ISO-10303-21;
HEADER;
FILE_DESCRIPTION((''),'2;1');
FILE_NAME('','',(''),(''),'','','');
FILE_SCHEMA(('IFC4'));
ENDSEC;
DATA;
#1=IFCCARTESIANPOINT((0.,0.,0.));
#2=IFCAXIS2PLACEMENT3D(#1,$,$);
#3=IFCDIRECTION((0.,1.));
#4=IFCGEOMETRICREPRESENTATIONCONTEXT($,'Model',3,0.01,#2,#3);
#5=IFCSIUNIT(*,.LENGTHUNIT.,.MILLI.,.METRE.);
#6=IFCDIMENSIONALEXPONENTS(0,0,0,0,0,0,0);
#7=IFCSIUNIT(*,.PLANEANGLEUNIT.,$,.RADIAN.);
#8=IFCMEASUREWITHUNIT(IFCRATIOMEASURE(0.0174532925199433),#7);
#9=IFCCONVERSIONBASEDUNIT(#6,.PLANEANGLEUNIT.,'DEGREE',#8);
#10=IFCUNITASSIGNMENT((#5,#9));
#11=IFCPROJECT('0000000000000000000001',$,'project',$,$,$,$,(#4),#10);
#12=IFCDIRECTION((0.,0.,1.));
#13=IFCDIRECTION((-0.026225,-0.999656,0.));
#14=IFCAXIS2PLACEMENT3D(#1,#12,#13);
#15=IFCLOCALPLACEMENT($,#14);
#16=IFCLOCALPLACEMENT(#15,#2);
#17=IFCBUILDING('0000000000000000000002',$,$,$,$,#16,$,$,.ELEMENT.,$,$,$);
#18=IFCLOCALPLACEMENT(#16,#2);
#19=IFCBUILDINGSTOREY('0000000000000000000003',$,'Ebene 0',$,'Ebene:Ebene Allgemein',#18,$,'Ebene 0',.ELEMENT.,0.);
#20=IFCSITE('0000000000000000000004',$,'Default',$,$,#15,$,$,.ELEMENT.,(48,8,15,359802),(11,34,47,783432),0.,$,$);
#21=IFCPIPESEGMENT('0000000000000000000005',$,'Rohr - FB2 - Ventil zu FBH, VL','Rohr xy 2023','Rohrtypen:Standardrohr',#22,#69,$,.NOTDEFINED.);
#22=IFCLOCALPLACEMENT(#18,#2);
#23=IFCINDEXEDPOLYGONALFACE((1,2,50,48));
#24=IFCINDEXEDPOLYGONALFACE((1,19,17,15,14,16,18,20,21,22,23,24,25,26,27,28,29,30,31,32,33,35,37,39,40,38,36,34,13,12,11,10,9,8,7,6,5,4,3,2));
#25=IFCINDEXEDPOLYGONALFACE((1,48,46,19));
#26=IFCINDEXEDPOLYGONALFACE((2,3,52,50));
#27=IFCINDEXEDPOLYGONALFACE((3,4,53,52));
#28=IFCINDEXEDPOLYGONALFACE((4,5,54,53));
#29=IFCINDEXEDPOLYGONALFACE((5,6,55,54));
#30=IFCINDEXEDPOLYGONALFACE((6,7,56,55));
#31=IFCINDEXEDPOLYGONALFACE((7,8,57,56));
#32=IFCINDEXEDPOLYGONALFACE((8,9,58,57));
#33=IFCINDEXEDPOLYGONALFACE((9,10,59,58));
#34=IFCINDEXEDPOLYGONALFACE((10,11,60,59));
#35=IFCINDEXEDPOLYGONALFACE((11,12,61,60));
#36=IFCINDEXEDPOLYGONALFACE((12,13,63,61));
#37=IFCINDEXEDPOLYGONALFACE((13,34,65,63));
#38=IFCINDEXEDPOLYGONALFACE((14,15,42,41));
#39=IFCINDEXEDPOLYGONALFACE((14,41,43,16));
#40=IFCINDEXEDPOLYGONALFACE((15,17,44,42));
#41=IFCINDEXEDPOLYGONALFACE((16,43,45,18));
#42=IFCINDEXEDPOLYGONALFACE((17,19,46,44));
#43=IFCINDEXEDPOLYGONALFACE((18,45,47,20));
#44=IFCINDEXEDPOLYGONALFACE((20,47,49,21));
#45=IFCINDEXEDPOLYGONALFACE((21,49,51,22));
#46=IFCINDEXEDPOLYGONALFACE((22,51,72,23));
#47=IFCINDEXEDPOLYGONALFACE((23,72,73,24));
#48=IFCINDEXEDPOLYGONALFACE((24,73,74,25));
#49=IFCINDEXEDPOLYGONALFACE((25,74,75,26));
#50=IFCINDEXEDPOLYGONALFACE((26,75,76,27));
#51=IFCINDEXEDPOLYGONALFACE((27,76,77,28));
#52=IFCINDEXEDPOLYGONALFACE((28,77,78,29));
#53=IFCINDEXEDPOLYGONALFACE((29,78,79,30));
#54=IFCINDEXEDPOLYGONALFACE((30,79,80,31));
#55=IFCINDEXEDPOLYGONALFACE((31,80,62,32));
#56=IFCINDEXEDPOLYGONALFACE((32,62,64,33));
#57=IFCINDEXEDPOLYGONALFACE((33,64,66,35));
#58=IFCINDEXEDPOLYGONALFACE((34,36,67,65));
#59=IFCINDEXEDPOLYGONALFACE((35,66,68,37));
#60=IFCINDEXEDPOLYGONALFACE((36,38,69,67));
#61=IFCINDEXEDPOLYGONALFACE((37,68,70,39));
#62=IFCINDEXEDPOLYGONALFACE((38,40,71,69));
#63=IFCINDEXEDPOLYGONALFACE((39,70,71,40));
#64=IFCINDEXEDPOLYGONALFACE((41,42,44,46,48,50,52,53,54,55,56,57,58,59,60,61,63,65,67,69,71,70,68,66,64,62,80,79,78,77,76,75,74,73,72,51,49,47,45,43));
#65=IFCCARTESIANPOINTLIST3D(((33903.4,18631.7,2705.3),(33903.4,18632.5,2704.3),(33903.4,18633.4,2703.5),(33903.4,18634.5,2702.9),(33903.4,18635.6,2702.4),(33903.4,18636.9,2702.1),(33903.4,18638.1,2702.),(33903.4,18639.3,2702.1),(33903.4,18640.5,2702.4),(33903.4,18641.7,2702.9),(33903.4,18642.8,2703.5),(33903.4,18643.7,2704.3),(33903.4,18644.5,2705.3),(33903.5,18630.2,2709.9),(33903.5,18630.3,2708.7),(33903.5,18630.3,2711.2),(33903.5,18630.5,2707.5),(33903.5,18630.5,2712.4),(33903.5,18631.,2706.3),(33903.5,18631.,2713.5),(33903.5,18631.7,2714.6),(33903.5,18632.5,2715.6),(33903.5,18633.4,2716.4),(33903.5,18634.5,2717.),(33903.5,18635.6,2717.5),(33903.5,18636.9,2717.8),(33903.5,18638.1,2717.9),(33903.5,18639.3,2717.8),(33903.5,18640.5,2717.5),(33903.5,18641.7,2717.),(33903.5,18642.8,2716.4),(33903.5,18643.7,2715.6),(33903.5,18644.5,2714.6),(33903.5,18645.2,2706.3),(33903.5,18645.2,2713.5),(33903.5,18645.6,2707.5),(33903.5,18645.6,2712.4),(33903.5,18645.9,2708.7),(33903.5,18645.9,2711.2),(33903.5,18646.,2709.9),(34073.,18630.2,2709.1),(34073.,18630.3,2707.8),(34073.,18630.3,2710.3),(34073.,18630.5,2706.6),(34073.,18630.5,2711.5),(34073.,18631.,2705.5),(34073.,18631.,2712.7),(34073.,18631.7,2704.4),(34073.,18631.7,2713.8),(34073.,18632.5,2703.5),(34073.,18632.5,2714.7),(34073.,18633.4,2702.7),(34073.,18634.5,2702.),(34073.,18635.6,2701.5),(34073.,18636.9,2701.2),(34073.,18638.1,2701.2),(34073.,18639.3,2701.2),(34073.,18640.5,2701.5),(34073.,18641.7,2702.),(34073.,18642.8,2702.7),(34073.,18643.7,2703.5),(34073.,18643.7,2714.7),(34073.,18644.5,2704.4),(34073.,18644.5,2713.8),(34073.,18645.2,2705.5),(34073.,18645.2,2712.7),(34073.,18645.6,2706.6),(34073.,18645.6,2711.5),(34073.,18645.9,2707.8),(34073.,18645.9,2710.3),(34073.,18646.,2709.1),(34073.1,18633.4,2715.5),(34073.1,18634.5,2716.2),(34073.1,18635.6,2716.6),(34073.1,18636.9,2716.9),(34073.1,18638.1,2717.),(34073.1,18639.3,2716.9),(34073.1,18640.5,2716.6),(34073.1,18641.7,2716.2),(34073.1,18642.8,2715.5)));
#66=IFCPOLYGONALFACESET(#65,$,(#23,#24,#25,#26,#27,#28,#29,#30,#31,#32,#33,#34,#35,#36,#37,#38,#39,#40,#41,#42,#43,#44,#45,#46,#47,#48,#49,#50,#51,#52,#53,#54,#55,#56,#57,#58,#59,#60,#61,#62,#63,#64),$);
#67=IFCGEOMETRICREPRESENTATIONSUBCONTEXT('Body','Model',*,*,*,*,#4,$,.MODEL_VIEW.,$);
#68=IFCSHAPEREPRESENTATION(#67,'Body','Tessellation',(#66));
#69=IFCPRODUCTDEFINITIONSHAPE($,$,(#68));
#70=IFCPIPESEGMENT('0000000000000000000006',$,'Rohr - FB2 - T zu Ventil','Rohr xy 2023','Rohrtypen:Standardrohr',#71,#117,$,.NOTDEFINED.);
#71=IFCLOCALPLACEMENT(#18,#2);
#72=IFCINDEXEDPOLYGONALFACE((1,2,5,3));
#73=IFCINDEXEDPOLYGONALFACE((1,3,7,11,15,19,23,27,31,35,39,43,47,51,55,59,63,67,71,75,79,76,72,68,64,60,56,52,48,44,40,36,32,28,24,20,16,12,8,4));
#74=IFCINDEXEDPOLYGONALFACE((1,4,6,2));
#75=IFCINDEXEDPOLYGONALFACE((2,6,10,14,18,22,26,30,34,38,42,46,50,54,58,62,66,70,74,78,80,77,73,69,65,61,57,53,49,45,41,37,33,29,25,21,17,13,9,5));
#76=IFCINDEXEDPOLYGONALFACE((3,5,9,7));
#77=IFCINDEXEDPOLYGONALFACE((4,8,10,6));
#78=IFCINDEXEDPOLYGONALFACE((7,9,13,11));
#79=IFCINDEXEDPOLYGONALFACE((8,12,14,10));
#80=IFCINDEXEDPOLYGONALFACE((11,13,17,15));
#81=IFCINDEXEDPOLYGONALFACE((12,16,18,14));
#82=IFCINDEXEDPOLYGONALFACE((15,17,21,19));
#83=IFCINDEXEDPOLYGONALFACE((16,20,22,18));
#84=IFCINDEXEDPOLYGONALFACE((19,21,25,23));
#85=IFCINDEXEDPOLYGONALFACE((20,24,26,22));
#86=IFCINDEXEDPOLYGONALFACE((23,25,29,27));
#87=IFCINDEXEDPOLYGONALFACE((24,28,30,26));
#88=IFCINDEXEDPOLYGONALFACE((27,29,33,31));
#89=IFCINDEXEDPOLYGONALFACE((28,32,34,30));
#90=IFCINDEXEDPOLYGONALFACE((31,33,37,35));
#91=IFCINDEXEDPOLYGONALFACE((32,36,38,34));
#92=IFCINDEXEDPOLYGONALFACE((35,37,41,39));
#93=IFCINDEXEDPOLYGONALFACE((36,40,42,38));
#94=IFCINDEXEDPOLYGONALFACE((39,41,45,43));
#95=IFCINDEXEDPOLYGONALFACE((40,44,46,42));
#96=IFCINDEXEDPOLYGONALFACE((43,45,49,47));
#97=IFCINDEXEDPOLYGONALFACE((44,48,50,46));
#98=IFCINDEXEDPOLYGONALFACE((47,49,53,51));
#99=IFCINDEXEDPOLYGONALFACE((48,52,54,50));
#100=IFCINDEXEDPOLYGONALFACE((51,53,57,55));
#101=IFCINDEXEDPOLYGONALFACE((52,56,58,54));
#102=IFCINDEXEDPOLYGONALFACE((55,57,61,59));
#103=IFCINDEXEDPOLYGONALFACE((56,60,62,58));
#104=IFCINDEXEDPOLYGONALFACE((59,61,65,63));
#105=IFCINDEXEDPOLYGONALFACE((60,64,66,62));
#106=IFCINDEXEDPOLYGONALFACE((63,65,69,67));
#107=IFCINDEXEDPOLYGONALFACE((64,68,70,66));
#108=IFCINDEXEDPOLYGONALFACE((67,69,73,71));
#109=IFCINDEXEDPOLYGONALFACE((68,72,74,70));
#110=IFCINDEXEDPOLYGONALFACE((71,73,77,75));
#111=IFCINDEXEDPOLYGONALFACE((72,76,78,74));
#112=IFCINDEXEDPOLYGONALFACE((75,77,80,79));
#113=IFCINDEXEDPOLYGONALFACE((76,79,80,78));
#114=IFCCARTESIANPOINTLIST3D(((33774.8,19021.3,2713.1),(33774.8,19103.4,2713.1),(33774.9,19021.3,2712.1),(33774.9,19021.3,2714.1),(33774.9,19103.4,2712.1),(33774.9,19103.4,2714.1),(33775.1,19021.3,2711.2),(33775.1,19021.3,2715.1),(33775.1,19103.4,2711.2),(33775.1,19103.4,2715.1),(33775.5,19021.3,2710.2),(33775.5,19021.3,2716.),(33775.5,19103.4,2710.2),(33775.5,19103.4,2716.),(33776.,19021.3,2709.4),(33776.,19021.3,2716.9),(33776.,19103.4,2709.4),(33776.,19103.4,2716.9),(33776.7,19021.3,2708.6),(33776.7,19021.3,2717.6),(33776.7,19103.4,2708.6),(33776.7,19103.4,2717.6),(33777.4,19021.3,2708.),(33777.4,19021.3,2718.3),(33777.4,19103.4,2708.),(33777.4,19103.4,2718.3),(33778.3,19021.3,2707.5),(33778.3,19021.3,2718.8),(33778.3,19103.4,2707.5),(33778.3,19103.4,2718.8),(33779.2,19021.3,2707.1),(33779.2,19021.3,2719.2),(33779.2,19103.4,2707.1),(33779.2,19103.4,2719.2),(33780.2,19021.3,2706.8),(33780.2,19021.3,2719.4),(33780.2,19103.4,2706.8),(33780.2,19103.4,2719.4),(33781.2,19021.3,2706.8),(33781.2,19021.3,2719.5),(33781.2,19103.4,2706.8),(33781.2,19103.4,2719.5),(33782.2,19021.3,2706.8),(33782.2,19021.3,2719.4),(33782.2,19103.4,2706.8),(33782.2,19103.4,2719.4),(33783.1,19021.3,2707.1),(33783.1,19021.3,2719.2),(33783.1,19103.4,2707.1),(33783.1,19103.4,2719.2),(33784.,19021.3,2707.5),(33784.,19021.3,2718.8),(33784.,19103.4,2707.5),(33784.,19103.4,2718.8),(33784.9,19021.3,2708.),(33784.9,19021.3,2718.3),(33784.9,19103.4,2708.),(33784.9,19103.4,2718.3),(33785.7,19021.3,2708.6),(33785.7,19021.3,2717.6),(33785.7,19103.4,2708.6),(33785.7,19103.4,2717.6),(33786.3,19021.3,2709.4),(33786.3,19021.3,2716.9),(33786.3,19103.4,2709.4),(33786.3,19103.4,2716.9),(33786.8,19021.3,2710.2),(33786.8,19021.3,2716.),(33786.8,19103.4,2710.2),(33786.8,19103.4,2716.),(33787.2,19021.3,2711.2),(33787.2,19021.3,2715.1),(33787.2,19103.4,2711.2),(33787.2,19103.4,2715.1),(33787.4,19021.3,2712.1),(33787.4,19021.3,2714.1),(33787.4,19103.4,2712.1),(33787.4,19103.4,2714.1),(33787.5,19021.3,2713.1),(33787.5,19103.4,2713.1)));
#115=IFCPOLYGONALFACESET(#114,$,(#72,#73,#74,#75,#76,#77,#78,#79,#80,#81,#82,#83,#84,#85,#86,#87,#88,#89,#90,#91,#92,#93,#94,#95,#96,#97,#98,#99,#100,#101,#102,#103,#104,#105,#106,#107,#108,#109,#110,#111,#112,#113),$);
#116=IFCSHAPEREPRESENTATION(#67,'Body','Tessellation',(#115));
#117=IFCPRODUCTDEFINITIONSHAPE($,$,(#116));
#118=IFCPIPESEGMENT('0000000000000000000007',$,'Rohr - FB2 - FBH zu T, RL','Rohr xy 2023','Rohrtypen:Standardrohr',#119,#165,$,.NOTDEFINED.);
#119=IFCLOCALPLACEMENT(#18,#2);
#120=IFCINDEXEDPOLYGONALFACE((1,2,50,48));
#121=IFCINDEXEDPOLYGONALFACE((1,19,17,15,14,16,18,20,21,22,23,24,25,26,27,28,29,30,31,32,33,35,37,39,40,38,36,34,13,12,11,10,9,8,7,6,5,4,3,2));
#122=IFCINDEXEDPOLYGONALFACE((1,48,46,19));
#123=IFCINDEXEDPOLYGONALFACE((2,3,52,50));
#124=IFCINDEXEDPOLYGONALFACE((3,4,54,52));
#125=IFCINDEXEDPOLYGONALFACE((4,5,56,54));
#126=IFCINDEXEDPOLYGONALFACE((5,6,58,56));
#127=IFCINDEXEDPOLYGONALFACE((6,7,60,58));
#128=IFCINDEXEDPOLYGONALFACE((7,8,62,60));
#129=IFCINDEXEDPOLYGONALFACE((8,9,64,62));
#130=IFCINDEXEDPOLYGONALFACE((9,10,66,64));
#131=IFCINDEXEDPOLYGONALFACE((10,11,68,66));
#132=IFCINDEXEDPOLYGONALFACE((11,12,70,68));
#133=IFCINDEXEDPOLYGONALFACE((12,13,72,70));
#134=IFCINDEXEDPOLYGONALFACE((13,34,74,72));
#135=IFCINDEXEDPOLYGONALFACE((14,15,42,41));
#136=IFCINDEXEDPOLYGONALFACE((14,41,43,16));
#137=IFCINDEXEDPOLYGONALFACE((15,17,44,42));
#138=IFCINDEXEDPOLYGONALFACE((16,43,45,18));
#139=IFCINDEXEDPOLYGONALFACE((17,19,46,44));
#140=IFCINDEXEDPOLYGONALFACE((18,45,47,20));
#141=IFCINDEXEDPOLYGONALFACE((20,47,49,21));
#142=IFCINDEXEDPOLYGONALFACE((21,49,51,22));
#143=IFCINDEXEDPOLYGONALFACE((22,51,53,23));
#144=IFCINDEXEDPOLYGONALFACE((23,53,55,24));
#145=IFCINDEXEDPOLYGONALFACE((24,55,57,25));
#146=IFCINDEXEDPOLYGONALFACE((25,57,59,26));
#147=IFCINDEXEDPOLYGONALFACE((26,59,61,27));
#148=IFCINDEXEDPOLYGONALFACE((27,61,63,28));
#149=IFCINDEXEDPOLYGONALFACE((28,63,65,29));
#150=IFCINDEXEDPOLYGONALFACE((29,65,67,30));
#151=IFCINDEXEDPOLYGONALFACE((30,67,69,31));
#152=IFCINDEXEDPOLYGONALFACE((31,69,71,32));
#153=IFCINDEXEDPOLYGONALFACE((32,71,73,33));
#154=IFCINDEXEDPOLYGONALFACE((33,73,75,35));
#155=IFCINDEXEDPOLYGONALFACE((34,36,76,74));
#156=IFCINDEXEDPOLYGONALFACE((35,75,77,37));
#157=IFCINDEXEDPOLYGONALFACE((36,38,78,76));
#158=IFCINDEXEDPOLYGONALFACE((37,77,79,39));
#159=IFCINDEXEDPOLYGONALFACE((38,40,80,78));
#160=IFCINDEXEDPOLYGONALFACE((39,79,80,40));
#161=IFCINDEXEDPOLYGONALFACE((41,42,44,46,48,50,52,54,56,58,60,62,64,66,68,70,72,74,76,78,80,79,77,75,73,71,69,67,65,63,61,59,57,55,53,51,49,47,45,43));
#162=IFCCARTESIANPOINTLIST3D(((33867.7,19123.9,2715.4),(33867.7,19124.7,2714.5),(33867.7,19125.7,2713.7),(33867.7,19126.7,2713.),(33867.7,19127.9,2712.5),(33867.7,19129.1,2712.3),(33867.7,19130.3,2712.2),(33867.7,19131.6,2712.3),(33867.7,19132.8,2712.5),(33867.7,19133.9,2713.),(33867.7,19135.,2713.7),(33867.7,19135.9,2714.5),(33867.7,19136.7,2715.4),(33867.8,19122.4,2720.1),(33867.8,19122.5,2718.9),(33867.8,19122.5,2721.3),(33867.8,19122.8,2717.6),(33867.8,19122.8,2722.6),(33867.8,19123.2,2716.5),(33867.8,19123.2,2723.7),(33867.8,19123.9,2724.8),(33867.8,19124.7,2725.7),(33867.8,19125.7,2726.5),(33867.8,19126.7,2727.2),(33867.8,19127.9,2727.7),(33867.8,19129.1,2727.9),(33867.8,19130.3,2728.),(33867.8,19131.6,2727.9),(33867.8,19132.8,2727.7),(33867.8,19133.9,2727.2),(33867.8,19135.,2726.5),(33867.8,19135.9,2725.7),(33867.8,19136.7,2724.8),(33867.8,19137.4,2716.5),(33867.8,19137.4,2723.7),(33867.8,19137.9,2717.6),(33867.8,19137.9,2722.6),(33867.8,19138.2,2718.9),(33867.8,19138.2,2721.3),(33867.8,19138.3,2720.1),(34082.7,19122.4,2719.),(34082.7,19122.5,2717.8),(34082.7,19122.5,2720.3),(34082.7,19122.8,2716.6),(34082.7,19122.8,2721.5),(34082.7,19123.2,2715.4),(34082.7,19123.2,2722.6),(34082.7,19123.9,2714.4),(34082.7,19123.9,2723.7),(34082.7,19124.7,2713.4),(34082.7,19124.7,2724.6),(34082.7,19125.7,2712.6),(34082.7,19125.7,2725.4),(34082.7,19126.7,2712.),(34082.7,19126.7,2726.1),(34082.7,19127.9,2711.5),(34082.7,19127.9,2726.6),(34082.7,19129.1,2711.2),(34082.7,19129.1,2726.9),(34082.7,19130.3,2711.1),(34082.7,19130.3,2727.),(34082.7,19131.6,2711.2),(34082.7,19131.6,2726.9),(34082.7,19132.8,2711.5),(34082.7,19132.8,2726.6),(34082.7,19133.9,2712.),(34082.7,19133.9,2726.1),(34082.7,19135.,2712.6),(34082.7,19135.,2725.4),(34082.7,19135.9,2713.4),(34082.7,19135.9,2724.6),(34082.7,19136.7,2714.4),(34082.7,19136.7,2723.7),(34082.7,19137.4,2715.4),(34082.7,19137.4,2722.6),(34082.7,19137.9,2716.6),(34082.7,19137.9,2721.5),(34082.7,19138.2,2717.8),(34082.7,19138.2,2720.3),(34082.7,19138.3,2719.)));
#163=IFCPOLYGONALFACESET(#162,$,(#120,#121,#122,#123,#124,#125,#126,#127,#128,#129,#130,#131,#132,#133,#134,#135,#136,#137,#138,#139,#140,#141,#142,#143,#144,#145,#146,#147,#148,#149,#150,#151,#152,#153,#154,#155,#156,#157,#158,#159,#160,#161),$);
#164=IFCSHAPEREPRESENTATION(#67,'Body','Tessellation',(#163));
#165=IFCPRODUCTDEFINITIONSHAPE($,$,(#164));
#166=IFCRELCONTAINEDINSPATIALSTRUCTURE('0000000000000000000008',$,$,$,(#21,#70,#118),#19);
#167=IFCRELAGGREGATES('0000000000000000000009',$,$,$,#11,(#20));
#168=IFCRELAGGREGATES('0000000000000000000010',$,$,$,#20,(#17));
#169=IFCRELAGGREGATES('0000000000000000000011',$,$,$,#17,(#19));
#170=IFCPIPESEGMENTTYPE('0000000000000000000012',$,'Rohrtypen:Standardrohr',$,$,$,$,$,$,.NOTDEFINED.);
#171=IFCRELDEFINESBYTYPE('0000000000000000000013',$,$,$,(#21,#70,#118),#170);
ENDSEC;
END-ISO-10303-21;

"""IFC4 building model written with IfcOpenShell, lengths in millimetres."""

from ifc_helpers import new_model, entity, si_unit, converted_unit, direction, frame, origin, place, context, subcontext, project, spatial, indexed_curve, outline, extrude, type_object, element, save


model = new_model("IFC4")

# Units and contexts
model_context = context("Model", 3, precision=0.01, world=origin(), true_north=direction((0.0, 1.0)))
body_context = subcontext(model_context, "Body", "Model", "MODEL_VIEW")
ifc_project = project(units=[si_unit("LENGTHUNIT", "METRE", prefix="MILLI"), converted_unit("PLANEANGLEUNIT", "DEGREE", entity("IfcRatioMeasure", 0.0174532925199433), si_unit("PLANEANGLEUNIT", "RADIAN"), dimensions=[0, 0, 0, 0, 0, 0, 0])], contexts=[model_context])

# Site, building, storey
site_placement = place(None, frame((0.0, 0.0, 0.0), z_axis=(0.0, 0.0, 1.0), x_axis=(-0.026225, -0.999656, 0.0)))
site = spatial("IfcSite", under=ifc_project, at=site_placement, Name="Default", CompositionType="ELEMENT", RefLatitude=(48, 8, 15, 359802), RefLongitude=(11, 34, 47, 783432), RefElevation=0.0)
building_placement = place(site_placement, origin())
building = spatial("IfcBuilding", under=site, at=building_placement, CompositionType="ELEMENT")
storey_placement = place(building_placement, origin())
storey = spatial("IfcBuildingStorey", under=building, at=storey_placement, Name="Ebene 0", ObjectType="Ebene:Ebene Allgemein", LongName="Ebene 0", CompositionType="ELEMENT", Elevation=0.0)

# Pipe segments
pipe_segment_type = type_object("IfcPipeSegmentType", Name="Rohrtypen:Standardrohr", PredefinedType="NOTDEFINED")
pipe_segment_1_placement = place(storey_placement, origin())
element("IfcPipeSegment", 1, at=pipe_segment_1_placement, inside=storey, type_object=pipe_segment_type, Name="Rohr - FB2 - Ventil zu FBH, VL", Description="Rohr xy 2023", ObjectType="Rohrtypen:Standardrohr", PredefinedType="NOTDEFINED", context=body_context, shape_type="SweptSolid", body=[
    extrude(outline(indexed_curve([(7.9, 0.0), (7.8, 1.2), (7.6, 2.5), (7.1, 3.6), (6.4, 4.7), (5.6, 5.6), (4.7, 6.4), (3.6, 7.1), (2.5, 7.6), (1.2, 7.8), (0.0, 7.9), (-1.2, 7.8), (-2.5, 7.6), (-3.6, 7.1), (-4.7, 6.4), (-5.6, 5.6), (-6.4, 4.7), (-7.1, 3.6), (-7.6, 2.5), (-7.8, 1.2), (-7.9, 0.0), (-7.8, -1.2), (-7.6, -2.5), (-7.1, -3.6), (-6.4, -4.7), (-5.6, -5.6), (-4.7, -6.4), (-3.6, -7.1), (-2.5, -7.6), (-1.2, -7.8), (0.0, -7.9), (1.2, -7.8), (2.5, -7.6), (3.6, -7.1), (4.7, -6.4), (5.6, -5.6), (6.4, -4.7), (7.1, -3.6), (7.6, -2.5), (7.8, -1.2), (7.9, 0.0)], self_intersect=False)), frame((33903.5, 18638.1, 2709.9), z_axis=(0.999988, 0.0, -0.005), x_axis=(0.0, 1.0, 0.0)), (0.0, 0.0, 1.0), 169.5),
])
pipe_segment_2_placement = place(storey_placement, origin())
element("IfcPipeSegment", 2, at=pipe_segment_2_placement, inside=storey, type_object=pipe_segment_type, Name="Rohr - FB2 - T zu Ventil", Description="Rohr xy 2023", ObjectType="Rohrtypen:Standardrohr", PredefinedType="NOTDEFINED", context=body_context, shape_type="SweptSolid", body=[
    extrude(outline(indexed_curve([(6.3, 0.0), (6.3, 1.0), (6.0, 2.0), (5.7, 2.9), (5.1, 3.7), (4.5, 4.5), (3.7, 5.1), (2.9, 5.7), (2.0, 6.0), (1.0, 6.3), (0.0, 6.4), (-1.0, 6.3), (-2.0, 6.0), (-2.9, 5.7), (-3.7, 5.1), (-4.5, 4.5), (-5.1, 3.7), (-5.7, 2.9), (-6.0, 2.0), (-6.3, 1.0), (-6.3, 0.0), (-6.3, -1.0), (-6.0, -2.0), (-5.7, -2.9), (-5.1, -3.7), (-4.5, -4.5), (-3.7, -5.1), (-2.9, -5.7), (-2.0, -6.0), (-1.0, -6.3), (0.0, -6.4), (1.0, -6.3), (2.0, -6.0), (2.9, -5.7), (3.7, -5.1), (4.5, -4.5), (5.1, -3.7), (5.7, -2.9), (6.0, -2.0), (6.3, -1.0), (6.3, 0.0)], self_intersect=False)), frame((33781.2, 19021.3, 2713.1), z_axis=(0.0, 1.0, 0.0), x_axis=(-1.0, 0.0, 0.0)), (0.0, 0.0, 1.0), 82.2),
])
pipe_segment_3_placement = place(storey_placement, origin())
element("IfcPipeSegment", 3, at=pipe_segment_3_placement, inside=storey, type_object=pipe_segment_type, Name="Rohr - FB2 - FBH zu T, RL", Description="Rohr xy 2023", ObjectType="Rohrtypen:Standardrohr", PredefinedType="NOTDEFINED", context=body_context, shape_type="SweptSolid", body=[
    extrude(outline(indexed_curve([(7.9, 0.0), (7.8, 1.2), (7.6, 2.5), (7.1, 3.6), (6.4, 4.7), (5.6, 5.6), (4.7, 6.4), (3.6, 7.1), (2.5, 7.6), (1.2, 7.8), (0.0, 7.9), (-1.2, 7.8), (-2.5, 7.6), (-3.6, 7.1), (-4.7, 6.4), (-5.6, 5.6), (-6.4, 4.7), (-7.1, 3.6), (-7.6, 2.5), (-7.8, 1.2), (-7.9, 0.0), (-7.8, -1.2), (-7.6, -2.5), (-7.1, -3.6), (-6.4, -4.7), (-5.6, -5.6), (-4.7, -6.4), (-3.6, -7.1), (-2.5, -7.6), (-1.2, -7.8), (0.0, -7.9), (1.2, -7.8), (2.5, -7.6), (3.6, -7.1), (4.7, -6.4), (5.6, -5.6), (6.4, -4.7), (7.1, -3.6), (7.6, -2.5), (7.8, -1.2), (7.9, 0.0)], self_intersect=False)), frame((34082.7, 19130.3, 2719.0), z_axis=(-0.999988, 0.0, 0.005), x_axis=(0.0, 1.0, 0.0)), (0.0, 0.0, 1.0), 214.9),
])

save(model, "model.ifc")
